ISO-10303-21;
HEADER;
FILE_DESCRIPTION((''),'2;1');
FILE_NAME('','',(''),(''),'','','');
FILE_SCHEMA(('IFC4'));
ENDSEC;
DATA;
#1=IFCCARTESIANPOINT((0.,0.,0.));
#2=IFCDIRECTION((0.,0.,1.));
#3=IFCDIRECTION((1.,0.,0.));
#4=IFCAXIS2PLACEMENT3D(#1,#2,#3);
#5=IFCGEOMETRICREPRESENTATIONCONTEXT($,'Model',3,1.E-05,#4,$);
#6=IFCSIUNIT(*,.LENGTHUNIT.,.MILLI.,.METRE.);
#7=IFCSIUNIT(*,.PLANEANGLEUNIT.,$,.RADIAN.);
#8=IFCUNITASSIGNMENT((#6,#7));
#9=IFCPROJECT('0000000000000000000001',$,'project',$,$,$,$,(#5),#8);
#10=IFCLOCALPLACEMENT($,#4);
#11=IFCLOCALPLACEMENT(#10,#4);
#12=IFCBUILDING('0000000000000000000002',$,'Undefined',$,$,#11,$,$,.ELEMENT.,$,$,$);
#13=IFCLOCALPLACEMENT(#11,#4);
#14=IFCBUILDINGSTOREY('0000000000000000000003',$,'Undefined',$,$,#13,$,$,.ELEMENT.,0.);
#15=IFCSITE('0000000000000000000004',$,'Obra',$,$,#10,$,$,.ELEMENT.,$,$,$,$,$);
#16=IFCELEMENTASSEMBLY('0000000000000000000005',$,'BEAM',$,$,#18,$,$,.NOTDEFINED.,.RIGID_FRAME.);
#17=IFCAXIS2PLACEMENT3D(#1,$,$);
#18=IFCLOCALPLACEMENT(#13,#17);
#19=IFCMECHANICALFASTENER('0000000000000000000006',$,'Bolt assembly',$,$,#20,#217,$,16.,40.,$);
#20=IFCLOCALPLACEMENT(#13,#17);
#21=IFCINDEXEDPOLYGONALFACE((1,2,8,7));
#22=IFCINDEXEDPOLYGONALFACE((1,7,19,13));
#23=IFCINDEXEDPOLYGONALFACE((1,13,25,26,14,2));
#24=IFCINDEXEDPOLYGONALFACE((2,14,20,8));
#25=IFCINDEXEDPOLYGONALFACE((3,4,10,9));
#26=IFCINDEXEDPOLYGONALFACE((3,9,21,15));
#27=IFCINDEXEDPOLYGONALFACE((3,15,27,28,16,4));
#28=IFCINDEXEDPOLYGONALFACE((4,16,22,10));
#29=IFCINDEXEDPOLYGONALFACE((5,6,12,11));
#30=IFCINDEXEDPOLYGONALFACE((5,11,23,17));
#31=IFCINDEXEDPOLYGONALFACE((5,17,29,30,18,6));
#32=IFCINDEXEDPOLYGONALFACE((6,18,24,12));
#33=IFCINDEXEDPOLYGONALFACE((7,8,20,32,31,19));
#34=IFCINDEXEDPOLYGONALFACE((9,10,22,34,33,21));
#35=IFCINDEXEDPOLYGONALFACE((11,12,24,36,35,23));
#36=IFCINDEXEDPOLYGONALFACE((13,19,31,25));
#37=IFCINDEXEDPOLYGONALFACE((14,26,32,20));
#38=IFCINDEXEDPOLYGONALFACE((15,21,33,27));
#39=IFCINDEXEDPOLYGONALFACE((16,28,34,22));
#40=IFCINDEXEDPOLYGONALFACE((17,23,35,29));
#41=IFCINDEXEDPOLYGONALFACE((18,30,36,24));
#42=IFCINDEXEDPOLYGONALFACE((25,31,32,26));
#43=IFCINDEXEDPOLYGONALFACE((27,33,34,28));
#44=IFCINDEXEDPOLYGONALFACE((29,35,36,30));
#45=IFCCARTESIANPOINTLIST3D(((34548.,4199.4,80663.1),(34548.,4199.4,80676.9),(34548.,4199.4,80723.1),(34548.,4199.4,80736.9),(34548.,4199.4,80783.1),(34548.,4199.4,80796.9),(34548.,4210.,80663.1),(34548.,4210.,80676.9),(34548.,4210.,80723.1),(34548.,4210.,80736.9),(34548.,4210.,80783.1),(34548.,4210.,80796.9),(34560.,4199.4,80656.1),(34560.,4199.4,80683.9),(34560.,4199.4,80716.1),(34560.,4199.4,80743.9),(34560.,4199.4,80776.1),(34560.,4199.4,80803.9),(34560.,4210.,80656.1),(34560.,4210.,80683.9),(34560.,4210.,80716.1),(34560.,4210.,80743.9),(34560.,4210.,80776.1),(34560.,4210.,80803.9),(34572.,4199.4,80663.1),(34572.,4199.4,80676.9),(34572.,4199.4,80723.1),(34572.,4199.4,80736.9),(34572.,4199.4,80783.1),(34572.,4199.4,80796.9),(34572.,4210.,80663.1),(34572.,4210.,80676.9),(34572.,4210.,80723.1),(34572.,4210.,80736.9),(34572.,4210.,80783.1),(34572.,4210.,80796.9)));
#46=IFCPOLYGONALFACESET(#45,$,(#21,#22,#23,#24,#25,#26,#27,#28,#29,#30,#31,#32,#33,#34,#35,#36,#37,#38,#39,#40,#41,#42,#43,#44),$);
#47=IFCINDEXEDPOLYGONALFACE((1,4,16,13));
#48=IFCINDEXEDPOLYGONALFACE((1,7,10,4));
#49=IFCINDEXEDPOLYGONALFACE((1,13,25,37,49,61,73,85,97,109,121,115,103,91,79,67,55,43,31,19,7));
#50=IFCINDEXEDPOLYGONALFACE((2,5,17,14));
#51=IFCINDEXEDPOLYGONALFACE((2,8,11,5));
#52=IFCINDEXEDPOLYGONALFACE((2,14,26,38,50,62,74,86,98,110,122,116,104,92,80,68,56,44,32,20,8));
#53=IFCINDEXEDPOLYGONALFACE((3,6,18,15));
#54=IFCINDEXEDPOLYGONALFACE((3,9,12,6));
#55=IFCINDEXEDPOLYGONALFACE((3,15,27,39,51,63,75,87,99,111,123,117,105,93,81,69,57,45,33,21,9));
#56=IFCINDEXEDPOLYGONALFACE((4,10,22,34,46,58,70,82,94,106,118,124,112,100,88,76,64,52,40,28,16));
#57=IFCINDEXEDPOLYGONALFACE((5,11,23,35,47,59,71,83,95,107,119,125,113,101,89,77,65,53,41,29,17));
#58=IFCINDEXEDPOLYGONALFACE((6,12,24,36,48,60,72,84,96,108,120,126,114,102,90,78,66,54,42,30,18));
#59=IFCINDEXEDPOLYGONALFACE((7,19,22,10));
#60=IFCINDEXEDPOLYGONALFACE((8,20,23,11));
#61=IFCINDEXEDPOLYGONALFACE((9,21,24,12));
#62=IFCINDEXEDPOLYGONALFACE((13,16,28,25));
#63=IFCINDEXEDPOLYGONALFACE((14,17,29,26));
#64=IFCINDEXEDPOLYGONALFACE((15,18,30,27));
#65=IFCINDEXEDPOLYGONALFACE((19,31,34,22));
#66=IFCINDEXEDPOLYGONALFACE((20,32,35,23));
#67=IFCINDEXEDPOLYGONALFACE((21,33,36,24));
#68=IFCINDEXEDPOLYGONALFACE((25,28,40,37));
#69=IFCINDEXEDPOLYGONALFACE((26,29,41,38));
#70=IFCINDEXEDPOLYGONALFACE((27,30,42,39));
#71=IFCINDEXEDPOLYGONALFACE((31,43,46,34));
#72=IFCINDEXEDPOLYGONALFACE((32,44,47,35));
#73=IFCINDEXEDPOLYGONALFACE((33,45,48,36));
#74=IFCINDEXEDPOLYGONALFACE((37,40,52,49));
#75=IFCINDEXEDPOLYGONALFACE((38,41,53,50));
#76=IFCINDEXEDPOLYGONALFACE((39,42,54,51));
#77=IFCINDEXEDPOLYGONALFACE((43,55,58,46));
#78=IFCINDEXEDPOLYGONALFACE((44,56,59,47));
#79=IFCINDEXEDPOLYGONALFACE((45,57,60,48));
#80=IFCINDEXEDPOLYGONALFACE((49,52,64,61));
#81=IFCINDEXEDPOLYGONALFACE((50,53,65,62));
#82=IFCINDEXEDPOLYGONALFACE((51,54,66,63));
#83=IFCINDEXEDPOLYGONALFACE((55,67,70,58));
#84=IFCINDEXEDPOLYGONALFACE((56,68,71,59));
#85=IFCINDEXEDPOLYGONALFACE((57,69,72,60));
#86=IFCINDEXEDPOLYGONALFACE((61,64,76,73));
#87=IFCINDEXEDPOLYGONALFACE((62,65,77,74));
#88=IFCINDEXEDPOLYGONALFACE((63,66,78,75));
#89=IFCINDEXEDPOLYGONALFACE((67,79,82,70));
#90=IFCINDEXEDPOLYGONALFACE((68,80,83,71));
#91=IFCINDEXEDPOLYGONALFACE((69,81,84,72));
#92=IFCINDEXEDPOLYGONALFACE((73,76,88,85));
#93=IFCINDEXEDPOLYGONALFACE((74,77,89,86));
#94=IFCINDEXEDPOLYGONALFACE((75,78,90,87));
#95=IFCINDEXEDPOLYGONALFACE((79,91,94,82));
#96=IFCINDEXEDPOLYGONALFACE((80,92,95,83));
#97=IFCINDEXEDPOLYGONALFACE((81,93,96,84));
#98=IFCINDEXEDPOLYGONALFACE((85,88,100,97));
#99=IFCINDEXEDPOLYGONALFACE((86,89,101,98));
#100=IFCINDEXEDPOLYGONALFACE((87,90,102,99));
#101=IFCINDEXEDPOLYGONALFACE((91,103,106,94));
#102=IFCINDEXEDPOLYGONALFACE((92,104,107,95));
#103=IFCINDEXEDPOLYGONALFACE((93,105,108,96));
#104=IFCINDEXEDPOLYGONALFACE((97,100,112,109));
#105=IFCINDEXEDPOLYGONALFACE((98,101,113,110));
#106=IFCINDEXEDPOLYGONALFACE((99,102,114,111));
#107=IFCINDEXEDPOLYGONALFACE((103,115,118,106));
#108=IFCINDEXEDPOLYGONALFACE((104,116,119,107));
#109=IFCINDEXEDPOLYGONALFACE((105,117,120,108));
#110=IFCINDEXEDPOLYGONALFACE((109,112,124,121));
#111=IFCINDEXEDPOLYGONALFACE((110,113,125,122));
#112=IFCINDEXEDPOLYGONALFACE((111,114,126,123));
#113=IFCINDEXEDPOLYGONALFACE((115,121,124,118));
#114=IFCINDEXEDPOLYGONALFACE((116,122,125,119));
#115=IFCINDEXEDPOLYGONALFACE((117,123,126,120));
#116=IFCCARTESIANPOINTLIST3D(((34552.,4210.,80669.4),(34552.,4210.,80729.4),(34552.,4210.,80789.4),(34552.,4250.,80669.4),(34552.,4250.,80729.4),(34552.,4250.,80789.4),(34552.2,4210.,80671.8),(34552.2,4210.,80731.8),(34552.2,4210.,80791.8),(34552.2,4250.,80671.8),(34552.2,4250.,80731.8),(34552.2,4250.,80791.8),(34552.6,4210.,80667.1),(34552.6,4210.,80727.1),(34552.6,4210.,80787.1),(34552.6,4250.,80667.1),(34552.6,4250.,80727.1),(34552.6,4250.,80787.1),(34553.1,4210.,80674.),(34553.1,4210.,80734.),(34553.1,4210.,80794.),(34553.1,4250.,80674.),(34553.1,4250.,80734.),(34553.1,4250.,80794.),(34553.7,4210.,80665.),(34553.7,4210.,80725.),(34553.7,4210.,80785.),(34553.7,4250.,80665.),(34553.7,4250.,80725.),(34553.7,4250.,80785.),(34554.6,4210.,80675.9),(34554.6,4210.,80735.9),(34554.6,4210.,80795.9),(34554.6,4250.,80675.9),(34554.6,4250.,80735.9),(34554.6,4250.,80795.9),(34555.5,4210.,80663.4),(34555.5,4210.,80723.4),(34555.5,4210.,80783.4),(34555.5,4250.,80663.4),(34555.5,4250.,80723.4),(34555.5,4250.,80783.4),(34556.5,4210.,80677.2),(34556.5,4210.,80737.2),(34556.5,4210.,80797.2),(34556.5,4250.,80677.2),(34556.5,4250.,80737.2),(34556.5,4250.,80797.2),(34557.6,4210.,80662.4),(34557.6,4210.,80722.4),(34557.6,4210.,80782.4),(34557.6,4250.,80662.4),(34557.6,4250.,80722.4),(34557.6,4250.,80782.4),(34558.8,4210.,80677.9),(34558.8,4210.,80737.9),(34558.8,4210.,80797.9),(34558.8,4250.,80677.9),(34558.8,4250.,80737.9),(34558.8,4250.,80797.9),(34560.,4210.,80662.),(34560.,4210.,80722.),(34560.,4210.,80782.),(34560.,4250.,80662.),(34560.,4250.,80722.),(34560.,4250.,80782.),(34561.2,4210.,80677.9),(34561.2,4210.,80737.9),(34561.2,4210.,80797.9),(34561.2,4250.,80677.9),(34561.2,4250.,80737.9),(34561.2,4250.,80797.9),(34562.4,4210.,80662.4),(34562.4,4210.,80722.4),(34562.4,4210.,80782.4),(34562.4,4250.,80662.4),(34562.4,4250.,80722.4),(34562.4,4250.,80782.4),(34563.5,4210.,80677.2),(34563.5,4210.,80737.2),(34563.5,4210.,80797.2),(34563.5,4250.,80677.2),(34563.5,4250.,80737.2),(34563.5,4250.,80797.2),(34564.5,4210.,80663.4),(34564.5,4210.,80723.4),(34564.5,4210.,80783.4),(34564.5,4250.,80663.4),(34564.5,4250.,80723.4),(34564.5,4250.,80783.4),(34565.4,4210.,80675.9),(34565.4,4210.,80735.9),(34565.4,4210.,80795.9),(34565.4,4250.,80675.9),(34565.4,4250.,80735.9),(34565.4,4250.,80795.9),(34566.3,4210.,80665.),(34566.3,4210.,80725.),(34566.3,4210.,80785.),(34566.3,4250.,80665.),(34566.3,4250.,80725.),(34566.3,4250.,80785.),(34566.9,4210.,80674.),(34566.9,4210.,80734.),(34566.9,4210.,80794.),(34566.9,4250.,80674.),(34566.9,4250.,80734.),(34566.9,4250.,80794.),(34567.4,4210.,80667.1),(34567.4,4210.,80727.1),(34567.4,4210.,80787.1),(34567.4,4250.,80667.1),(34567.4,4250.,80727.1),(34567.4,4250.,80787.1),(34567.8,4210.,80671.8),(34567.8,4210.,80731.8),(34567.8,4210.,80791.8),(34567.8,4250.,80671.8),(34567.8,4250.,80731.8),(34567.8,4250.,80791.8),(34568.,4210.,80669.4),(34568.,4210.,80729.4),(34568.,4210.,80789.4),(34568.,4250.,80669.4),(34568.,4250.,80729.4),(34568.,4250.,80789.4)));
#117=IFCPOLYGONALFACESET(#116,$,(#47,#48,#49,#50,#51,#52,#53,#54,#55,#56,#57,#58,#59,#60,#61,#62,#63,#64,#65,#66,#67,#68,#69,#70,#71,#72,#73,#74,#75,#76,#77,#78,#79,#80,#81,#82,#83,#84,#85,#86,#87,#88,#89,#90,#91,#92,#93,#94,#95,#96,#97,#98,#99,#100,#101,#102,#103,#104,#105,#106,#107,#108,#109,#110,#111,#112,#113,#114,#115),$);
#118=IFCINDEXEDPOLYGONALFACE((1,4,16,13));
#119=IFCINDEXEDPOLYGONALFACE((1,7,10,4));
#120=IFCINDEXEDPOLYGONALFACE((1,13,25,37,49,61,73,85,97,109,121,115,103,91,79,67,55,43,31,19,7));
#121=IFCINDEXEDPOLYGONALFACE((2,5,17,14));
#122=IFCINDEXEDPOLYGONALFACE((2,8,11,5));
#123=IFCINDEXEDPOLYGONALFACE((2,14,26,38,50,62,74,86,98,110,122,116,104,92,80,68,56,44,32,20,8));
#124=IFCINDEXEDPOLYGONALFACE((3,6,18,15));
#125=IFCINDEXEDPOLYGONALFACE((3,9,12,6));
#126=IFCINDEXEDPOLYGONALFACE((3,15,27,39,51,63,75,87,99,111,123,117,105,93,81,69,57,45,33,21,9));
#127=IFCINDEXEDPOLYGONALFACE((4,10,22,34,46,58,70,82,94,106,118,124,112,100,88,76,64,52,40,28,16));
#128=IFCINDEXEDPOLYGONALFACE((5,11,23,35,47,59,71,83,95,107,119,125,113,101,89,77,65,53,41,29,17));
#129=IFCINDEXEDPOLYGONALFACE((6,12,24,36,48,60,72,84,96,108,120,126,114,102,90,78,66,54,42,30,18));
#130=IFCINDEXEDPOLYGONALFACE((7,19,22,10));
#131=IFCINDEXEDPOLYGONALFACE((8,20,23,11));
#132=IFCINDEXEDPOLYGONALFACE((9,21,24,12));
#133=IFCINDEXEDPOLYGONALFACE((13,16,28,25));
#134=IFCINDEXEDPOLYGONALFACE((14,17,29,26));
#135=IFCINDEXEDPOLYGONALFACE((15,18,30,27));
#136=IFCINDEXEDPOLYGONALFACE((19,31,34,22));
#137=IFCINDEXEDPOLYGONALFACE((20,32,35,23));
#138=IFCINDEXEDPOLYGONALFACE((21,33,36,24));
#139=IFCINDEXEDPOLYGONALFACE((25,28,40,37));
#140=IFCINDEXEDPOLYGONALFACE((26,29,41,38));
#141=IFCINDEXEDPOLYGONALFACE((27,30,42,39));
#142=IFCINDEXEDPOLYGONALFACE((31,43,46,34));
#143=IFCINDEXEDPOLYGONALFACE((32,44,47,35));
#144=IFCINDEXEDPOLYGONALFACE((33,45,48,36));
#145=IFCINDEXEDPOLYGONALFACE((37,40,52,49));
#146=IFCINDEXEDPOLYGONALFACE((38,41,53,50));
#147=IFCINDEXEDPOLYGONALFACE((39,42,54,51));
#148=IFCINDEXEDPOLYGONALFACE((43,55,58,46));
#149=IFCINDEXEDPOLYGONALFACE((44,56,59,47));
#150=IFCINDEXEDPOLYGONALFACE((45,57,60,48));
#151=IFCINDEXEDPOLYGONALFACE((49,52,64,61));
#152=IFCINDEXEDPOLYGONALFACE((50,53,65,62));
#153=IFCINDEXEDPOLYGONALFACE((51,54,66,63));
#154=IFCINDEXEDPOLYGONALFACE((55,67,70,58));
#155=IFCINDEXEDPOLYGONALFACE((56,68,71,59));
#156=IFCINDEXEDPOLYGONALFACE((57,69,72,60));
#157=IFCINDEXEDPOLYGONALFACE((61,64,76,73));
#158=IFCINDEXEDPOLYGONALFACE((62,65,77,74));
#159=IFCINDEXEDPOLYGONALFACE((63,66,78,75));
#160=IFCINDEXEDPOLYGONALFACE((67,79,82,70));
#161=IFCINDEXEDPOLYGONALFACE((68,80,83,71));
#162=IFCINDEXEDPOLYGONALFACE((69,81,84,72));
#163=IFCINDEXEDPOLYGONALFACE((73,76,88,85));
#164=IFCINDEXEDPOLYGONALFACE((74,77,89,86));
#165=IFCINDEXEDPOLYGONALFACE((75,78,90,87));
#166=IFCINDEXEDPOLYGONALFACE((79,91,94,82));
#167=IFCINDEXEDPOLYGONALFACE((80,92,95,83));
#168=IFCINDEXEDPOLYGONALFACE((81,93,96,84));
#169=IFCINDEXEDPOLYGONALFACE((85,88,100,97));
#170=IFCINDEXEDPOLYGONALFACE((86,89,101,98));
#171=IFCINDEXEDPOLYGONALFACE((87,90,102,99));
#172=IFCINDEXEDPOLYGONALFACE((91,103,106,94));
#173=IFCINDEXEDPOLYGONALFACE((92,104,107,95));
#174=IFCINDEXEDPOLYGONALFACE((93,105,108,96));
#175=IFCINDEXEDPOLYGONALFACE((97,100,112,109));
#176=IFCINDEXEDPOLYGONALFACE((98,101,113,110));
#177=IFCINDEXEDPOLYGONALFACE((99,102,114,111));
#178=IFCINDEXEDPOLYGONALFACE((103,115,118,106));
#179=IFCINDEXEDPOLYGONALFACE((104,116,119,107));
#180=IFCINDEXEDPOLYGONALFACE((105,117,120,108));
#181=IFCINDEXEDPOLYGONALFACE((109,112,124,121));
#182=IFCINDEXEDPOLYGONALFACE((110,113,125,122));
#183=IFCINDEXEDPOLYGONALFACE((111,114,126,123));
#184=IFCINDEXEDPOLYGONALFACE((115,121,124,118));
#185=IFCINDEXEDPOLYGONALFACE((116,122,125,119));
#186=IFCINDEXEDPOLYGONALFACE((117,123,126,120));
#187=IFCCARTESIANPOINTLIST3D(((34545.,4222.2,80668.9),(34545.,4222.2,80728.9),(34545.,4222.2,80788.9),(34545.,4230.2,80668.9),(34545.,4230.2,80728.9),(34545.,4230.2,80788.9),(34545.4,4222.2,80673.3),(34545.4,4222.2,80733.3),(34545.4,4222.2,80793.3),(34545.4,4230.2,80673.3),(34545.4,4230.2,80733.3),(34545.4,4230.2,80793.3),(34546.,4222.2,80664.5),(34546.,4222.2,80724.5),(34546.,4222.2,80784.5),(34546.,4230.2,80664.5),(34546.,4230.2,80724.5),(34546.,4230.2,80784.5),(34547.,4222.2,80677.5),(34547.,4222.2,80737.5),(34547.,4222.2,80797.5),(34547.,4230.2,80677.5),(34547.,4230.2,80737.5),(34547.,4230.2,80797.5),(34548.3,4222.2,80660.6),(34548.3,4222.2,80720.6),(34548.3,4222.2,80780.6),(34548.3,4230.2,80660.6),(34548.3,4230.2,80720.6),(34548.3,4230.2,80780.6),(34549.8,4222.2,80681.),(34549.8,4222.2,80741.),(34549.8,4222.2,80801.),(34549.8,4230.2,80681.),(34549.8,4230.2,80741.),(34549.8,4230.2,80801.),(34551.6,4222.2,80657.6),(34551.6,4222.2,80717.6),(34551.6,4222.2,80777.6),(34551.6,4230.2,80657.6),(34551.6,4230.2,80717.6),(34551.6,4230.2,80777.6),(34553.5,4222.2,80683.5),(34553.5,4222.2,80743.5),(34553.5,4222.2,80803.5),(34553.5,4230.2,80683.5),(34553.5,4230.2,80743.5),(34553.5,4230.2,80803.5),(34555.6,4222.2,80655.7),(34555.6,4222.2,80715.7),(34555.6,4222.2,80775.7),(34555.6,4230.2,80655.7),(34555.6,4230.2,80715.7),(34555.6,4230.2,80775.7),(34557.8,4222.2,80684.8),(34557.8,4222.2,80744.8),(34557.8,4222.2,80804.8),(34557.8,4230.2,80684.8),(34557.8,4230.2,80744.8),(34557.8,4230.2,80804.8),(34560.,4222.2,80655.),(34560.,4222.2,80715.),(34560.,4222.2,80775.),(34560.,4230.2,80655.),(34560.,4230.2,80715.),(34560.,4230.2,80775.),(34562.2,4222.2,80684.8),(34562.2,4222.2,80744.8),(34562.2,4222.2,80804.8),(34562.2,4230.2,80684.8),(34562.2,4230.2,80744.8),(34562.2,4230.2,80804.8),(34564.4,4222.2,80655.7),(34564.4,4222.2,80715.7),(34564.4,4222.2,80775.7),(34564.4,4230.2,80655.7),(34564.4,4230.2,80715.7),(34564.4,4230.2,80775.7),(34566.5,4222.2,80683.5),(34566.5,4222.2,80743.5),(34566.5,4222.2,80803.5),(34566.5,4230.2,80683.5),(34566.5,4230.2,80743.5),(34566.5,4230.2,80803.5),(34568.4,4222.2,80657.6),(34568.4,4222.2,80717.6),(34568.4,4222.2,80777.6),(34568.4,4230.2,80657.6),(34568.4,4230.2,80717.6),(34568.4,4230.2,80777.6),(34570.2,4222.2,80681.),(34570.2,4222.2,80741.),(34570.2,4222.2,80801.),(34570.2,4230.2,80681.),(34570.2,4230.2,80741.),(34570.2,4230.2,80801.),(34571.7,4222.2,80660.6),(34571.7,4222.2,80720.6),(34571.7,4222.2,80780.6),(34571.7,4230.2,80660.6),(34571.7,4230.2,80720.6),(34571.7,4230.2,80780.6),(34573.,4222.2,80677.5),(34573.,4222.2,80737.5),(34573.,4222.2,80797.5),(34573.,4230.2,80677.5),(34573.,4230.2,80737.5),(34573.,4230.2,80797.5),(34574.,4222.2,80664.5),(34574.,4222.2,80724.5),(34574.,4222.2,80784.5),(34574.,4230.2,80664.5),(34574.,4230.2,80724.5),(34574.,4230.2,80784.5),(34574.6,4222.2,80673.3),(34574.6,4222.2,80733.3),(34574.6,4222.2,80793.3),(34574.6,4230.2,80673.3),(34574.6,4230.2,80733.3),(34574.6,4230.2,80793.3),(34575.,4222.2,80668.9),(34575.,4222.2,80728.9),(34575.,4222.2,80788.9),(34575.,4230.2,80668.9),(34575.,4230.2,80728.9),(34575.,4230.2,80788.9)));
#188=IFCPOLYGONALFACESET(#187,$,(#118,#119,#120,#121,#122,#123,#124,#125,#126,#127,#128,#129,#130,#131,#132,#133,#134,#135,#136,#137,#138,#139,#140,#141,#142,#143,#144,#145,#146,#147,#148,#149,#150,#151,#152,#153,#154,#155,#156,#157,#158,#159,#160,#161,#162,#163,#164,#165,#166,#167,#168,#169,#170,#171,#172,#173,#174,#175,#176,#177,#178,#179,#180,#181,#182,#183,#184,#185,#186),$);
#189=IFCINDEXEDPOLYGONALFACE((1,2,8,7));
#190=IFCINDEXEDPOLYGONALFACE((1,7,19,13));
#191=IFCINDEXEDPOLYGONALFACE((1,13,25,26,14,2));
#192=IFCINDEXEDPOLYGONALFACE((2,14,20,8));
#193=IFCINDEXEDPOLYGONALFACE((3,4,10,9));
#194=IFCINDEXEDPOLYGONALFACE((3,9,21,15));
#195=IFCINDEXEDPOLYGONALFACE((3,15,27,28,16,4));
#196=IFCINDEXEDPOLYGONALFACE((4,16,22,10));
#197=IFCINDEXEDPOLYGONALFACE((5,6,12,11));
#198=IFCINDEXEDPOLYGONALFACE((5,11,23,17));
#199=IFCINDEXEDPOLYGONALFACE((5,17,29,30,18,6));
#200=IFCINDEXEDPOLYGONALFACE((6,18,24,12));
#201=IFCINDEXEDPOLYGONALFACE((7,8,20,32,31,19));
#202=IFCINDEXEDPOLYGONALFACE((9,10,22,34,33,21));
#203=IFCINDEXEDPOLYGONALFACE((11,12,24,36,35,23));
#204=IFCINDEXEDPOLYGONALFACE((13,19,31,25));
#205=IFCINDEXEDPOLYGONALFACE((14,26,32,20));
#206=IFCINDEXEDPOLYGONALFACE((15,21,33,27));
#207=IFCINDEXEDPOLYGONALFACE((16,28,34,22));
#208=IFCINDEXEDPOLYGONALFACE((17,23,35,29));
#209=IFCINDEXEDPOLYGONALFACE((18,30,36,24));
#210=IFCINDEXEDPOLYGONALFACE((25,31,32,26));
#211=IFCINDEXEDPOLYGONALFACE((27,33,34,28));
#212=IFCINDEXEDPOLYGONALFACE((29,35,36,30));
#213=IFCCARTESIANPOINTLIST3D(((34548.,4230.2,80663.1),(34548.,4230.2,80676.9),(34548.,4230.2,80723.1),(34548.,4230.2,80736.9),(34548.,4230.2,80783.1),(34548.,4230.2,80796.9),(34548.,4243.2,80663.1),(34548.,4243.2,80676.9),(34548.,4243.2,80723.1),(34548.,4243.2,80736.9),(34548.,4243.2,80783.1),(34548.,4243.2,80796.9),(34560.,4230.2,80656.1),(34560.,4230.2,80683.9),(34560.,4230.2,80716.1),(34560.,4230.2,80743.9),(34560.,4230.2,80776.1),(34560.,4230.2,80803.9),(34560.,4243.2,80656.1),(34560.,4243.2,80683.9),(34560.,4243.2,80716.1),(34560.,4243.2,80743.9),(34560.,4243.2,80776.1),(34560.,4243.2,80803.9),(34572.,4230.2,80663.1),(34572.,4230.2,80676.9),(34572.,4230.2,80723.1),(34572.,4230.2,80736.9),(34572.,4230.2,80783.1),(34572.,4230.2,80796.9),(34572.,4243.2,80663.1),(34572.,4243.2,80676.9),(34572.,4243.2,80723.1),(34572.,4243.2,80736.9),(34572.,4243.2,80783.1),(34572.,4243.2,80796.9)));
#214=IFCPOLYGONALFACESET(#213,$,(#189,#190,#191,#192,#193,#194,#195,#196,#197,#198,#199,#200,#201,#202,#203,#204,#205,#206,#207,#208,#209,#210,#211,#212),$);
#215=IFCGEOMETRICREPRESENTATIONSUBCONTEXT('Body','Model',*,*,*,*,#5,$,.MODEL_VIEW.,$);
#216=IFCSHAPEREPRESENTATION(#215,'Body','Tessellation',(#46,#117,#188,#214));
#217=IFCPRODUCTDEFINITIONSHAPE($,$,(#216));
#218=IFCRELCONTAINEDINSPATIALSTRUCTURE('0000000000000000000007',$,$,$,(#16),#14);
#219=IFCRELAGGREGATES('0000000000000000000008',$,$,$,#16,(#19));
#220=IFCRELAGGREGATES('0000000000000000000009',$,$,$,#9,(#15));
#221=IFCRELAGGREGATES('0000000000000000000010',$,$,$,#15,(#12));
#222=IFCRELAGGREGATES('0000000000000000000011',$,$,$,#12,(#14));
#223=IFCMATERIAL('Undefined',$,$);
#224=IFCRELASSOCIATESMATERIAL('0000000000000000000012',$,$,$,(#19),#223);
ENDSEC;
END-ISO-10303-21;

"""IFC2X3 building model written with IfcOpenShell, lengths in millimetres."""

from ifc_helpers import new_model, si_unit, frame, origin_with_axes, origin_2d_with_axis, place, context, subcontext, project, spatial, polyline, circle, outline, extrude, source, transform, mapped, material, element, aggregate, save


model = new_model("IFC2X3")

# Units and contexts
model_context = context("Model", 3, precision=1e-05, world=origin_with_axes())
body_context = subcontext(model_context, "Body", "Model", "MODEL_VIEW")
ifc_project = project(units=[si_unit("LENGTHUNIT", "METRE", prefix="MILLI"), si_unit("PLANEANGLEUNIT", "RADIAN")], contexts=[model_context])

# Site, building, storey
site_placement = place(None, origin_with_axes())
site = spatial("IfcSite", under=ifc_project, at=site_placement, Name="Obra", CompositionType="ELEMENT")
building_placement = place(site_placement, origin_with_axes())
building = spatial("IfcBuilding", under=site, at=building_placement, Name="Undefined", CompositionType="ELEMENT")
storey_placement = place(building_placement, origin_with_axes())
storey = spatial("IfcBuildingStorey", under=building, at=storey_placement, Name="Undefined", CompositionType="ELEMENT", Elevation=0.0)

# Shared definitions
ifc_material_1 = material(Name="Undefined")

# Element assembly, mechanical fastener
shared_shape_1 = source(origin_with_axes(), body_context, "Body", "SweptSolid", [
    extrude(outline(polyline([(13.9, 0.0), (6.9, 12.0), (-6.9, 12.0), (-13.9, 0.0), (-6.9, -12.0), (6.9, -12.0), (13.9, 0.0)])), frame((0.0, -19.7, 0.0), z_axis=(0.0, 1.0, 0.0), x_axis=(1.0, 0.0, 0.0)), (0.0, 0.0, 1.0), 10.6),
    extrude(circle(Radius=8.0, at=origin_2d_with_axis()), frame((0.0, -9.1, 0.0), z_axis=(0.0, 1.0, 0.0), x_axis=(1.0, 0.0, 0.0)), (0.0, 0.0, 1.0), 40.0),
    extrude(circle(Radius=15.0, at=origin_2d_with_axis()), frame((0.0, 3.1, 0.0), z_axis=(0.0, 1.0, 0.0), x_axis=(1.0, 0.0, 0.0)), (0.0, 0.0, 1.0), 8.0),
    extrude(outline(polyline([(13.9, 0.0), (6.9, 12.0), (-6.9, 12.0), (-13.9, 0.0), (-6.9, -12.0), (6.9, -12.0), (13.9, 0.0)])), frame((0.0, 11.1, 0.0), z_axis=(0.0, 1.0, 0.0), x_axis=(1.0, 0.0, 0.0)), (0.0, 0.0, 1.0), 13.0),
])
assembly_1_placement = place(storey_placement, origin_with_axes())
assembly_1 = element("IfcElementAssembly", 1, at=assembly_1_placement, inside=storey, Name="BEAM", AssemblyPlace="NOTDEFINED", PredefinedType="RIGID_FRAME")
mechanical_fastener_1_placement = place(assembly_1_placement, frame((34510.0, 4219.1, 80850.0), z_axis=(1.0, 0.0, 0.0), x_axis=(0.0, 0.0, -1.0)))
mechanical_fastener_1 = element("IfcMechanicalFastener", 2, at=mechanical_fastener_1_placement, material=ifc_material_1, Name="Bolt assembly", NominalDiameter=16.0, NominalLength=40.0, context=body_context, shape_type="MappedRepresentation", body=[
    mapped(shared_shape_1, transform((60.0, 0.0, 50.0))),
    mapped(shared_shape_1, transform((120.0, 0.0, 50.0))),
    mapped(shared_shape_1, transform((180.0, 0.0, 50.0))),
])
aggregate(assembly_1, [mechanical_fastener_1])

save(model, "model.ifc")
